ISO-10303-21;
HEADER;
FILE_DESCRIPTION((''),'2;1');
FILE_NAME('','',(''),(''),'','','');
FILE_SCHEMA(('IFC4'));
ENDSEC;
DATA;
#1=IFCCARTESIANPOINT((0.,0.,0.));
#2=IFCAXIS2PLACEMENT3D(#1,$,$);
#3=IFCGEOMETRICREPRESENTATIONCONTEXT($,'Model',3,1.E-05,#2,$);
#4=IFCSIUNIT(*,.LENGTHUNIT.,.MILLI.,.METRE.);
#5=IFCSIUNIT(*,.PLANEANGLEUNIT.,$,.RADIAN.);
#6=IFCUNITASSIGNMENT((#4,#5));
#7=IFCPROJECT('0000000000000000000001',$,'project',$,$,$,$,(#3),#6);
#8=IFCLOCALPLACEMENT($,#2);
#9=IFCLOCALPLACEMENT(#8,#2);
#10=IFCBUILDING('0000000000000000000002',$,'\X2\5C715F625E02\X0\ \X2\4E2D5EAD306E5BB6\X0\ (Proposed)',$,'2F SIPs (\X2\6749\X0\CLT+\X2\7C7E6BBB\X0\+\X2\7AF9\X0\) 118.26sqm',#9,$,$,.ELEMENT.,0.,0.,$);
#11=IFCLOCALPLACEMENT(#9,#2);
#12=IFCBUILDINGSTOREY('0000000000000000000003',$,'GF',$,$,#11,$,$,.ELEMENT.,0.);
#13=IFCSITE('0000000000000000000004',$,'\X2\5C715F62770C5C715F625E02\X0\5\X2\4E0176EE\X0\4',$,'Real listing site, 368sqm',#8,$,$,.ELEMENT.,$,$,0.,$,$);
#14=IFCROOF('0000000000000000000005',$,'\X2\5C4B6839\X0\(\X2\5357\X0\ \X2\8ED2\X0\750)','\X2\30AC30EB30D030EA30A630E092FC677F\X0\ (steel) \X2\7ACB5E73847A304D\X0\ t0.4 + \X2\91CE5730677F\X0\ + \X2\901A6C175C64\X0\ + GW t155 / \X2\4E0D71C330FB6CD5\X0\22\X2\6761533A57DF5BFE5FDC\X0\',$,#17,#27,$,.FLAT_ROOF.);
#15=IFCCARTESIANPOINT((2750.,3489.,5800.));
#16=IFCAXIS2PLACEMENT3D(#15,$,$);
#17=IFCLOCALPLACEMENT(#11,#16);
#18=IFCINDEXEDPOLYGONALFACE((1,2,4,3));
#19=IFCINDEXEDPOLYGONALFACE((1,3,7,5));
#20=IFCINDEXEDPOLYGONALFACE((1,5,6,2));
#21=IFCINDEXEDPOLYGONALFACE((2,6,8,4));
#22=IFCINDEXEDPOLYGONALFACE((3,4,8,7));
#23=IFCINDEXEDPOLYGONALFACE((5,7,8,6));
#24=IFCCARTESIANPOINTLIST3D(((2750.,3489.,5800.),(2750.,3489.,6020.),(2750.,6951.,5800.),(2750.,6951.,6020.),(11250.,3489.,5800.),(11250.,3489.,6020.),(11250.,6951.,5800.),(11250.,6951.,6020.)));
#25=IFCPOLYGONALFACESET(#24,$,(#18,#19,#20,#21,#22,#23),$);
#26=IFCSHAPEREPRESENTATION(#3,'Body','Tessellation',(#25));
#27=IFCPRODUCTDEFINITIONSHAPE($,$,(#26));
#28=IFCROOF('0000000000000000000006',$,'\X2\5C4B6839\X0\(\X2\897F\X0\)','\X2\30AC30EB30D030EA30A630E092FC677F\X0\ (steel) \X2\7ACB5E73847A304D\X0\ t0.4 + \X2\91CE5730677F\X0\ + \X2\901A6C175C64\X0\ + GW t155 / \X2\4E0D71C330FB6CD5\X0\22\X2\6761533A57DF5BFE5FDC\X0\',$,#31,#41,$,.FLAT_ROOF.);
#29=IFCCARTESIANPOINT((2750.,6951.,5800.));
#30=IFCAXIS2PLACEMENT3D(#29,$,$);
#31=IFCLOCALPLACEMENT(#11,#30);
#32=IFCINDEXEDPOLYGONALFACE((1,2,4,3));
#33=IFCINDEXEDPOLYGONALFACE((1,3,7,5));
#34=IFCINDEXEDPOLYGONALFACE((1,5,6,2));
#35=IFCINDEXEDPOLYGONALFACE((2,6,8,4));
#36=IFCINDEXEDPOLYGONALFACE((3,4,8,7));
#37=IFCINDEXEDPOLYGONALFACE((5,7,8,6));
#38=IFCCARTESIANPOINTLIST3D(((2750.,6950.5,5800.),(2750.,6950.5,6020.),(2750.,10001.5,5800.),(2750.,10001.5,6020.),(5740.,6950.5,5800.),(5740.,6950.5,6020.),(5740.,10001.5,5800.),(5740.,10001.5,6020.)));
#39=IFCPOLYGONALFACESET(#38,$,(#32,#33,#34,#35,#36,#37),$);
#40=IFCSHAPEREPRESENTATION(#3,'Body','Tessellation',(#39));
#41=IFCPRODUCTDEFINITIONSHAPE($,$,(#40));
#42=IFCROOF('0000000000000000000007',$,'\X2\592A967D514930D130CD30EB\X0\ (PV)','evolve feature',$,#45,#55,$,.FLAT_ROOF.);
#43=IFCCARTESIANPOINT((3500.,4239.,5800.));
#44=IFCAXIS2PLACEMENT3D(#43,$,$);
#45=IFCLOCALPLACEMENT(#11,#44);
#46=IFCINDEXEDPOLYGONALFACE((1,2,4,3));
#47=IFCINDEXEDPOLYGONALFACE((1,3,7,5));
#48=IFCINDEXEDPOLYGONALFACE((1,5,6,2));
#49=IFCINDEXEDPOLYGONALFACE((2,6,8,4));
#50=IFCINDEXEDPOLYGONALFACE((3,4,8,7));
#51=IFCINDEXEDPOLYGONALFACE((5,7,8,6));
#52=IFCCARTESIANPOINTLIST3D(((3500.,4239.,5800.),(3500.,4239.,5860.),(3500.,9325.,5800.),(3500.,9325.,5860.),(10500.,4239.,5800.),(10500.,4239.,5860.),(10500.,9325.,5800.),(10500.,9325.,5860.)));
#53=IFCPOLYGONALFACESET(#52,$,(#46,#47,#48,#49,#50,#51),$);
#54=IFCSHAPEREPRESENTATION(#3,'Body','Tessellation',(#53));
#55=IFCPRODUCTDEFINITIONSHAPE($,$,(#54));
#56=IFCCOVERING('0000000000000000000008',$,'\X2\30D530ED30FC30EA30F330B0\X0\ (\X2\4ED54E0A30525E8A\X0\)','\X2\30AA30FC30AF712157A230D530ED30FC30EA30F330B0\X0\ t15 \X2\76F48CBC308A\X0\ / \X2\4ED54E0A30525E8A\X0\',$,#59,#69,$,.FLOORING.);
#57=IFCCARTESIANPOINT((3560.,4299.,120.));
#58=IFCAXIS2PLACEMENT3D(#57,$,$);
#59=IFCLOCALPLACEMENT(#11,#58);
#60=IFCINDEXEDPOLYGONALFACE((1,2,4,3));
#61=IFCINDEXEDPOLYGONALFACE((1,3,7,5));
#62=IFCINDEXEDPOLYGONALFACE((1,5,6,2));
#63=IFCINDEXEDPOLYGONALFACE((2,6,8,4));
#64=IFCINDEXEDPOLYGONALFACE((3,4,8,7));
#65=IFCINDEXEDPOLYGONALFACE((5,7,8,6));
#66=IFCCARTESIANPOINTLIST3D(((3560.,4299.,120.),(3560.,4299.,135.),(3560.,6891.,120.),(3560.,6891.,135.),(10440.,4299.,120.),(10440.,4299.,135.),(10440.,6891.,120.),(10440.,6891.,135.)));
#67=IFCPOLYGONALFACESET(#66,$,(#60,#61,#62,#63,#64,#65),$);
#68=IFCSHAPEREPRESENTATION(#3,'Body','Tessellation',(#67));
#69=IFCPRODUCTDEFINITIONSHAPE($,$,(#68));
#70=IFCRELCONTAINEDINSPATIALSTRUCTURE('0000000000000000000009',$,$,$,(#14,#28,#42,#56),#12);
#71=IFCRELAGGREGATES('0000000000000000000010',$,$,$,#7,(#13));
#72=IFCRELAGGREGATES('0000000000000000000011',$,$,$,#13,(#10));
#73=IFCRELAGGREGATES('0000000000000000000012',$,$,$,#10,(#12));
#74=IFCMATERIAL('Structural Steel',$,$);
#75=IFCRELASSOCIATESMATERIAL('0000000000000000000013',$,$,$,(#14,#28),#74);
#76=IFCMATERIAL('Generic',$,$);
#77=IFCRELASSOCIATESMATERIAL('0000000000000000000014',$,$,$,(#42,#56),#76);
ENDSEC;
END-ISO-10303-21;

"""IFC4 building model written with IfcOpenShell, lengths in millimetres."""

from ifc_helpers import new_model, si_unit, frame, frame_2d, origin, place, context, project, spatial, rectangle, extrude, material, element, save


model = new_model("IFC4")

# Units and contexts
model_context = context("Model", 3, precision=1e-05, world=origin())
ifc_project = project(units=[si_unit("LENGTHUNIT", "METRE", prefix="MILLI"), si_unit("PLANEANGLEUNIT", "RADIAN")], contexts=[model_context])

# Site, building, storey
site_placement = place(None, origin())
site = spatial("IfcSite", under=ifc_project, at=site_placement, Name="山形県山形市5丁目4", ObjectType="Real listing site, 368sqm", CompositionType="ELEMENT", RefElevation=0.0)
building_placement = place(site_placement, origin())
building = spatial("IfcBuilding", under=site, at=building_placement, Name="山形市 中庭の家 (Proposed)", ObjectType="2F SIPs (杉CLT+籾殻+竹) 118.26sqm", CompositionType="ELEMENT", ElevationOfRefHeight=0.0, ElevationOfTerrain=0.0)
storey_placement = place(building_placement, origin())
storey = spatial("IfcBuildingStorey", under=building, at=storey_placement, Name="GF", CompositionType="ELEMENT", Elevation=0.0)

# Shared definitions
ifc_material_1 = material(Name="Generic")

# Roofs
ifc_material_2 = material(Name="Structural Steel")
roof_1_placement = place(storey_placement, frame((2750.0, 3489.0, 5800.0)))
element("IfcRoof", 1, at=roof_1_placement, inside=storey, material=ifc_material_2, Name="屋根(南 軒750)", Description="ガルバリウム鋼板 (steel) 立平葺き t0.4 + 野地板 + 通気層 + GW t155 / 不燃・法22条区域対応", PredefinedType="FLAT_ROOF", context=model_context, shape_type="SweptSolid", body=[
    extrude(rectangle(XDim=8500.0, YDim=3462.0, at=frame_2d((4250.0, 1731.0))), frame((2750.0, 3489.0, 5800.0)), (0.0, 0.0, 1.0), 220.0),
])
roof_2_placement = place(storey_placement, frame((2750.0, 6951.0, 5800.0)))
element("IfcRoof", 2, at=roof_2_placement, inside=storey, material=ifc_material_2, Name="屋根(西)", Description="ガルバリウム鋼板 (steel) 立平葺き t0.4 + 野地板 + 通気層 + GW t155 / 不燃・法22条区域対応", PredefinedType="FLAT_ROOF", context=model_context, shape_type="SweptSolid", body=[
    extrude(rectangle(XDim=2990.0, YDim=3051.0, at=frame_2d((1495.0, 1525.0))), frame((2750.0, 6951.0, 5800.0)), (0.0, 0.0, 1.0), 220.0),
])
roof_3_placement = place(storey_placement, frame((3500.0, 4239.0, 5800.0)))
element("IfcRoof", 3, at=roof_3_placement, inside=storey, material=ifc_material_1, Name="太陽光パネル (PV)", Description="evolve feature", PredefinedType="FLAT_ROOF", context=model_context, shape_type="SweptSolid", body=[
    extrude(rectangle(XDim=7000.0, YDim=5086.0, at=frame_2d((3500.0, 2543.0))), frame((3500.0, 4239.0, 5800.0)), (0.0, 0.0, 1.0), 60.0),
])

# Covering
covering_placement = place(storey_placement, frame((3560.0, 4299.0, 120.0)))
element("IfcCovering", 4, at=covering_placement, inside=storey, material=ifc_material_1, Name="フローリング (仕上げ床)", Description="オーク無垢フローリング t15 直貼り / 仕上げ床", PredefinedType="FLOORING", context=model_context, shape_type="SweptSolid", body=[
    extrude(rectangle(XDim=6880.0, YDim=2592.0, at=frame_2d((3440.0, 1296.0))), frame((3560.0, 4299.0, 120.0)), (0.0, 0.0, 1.0), 15.0),
])

save(model, "model.ifc")
